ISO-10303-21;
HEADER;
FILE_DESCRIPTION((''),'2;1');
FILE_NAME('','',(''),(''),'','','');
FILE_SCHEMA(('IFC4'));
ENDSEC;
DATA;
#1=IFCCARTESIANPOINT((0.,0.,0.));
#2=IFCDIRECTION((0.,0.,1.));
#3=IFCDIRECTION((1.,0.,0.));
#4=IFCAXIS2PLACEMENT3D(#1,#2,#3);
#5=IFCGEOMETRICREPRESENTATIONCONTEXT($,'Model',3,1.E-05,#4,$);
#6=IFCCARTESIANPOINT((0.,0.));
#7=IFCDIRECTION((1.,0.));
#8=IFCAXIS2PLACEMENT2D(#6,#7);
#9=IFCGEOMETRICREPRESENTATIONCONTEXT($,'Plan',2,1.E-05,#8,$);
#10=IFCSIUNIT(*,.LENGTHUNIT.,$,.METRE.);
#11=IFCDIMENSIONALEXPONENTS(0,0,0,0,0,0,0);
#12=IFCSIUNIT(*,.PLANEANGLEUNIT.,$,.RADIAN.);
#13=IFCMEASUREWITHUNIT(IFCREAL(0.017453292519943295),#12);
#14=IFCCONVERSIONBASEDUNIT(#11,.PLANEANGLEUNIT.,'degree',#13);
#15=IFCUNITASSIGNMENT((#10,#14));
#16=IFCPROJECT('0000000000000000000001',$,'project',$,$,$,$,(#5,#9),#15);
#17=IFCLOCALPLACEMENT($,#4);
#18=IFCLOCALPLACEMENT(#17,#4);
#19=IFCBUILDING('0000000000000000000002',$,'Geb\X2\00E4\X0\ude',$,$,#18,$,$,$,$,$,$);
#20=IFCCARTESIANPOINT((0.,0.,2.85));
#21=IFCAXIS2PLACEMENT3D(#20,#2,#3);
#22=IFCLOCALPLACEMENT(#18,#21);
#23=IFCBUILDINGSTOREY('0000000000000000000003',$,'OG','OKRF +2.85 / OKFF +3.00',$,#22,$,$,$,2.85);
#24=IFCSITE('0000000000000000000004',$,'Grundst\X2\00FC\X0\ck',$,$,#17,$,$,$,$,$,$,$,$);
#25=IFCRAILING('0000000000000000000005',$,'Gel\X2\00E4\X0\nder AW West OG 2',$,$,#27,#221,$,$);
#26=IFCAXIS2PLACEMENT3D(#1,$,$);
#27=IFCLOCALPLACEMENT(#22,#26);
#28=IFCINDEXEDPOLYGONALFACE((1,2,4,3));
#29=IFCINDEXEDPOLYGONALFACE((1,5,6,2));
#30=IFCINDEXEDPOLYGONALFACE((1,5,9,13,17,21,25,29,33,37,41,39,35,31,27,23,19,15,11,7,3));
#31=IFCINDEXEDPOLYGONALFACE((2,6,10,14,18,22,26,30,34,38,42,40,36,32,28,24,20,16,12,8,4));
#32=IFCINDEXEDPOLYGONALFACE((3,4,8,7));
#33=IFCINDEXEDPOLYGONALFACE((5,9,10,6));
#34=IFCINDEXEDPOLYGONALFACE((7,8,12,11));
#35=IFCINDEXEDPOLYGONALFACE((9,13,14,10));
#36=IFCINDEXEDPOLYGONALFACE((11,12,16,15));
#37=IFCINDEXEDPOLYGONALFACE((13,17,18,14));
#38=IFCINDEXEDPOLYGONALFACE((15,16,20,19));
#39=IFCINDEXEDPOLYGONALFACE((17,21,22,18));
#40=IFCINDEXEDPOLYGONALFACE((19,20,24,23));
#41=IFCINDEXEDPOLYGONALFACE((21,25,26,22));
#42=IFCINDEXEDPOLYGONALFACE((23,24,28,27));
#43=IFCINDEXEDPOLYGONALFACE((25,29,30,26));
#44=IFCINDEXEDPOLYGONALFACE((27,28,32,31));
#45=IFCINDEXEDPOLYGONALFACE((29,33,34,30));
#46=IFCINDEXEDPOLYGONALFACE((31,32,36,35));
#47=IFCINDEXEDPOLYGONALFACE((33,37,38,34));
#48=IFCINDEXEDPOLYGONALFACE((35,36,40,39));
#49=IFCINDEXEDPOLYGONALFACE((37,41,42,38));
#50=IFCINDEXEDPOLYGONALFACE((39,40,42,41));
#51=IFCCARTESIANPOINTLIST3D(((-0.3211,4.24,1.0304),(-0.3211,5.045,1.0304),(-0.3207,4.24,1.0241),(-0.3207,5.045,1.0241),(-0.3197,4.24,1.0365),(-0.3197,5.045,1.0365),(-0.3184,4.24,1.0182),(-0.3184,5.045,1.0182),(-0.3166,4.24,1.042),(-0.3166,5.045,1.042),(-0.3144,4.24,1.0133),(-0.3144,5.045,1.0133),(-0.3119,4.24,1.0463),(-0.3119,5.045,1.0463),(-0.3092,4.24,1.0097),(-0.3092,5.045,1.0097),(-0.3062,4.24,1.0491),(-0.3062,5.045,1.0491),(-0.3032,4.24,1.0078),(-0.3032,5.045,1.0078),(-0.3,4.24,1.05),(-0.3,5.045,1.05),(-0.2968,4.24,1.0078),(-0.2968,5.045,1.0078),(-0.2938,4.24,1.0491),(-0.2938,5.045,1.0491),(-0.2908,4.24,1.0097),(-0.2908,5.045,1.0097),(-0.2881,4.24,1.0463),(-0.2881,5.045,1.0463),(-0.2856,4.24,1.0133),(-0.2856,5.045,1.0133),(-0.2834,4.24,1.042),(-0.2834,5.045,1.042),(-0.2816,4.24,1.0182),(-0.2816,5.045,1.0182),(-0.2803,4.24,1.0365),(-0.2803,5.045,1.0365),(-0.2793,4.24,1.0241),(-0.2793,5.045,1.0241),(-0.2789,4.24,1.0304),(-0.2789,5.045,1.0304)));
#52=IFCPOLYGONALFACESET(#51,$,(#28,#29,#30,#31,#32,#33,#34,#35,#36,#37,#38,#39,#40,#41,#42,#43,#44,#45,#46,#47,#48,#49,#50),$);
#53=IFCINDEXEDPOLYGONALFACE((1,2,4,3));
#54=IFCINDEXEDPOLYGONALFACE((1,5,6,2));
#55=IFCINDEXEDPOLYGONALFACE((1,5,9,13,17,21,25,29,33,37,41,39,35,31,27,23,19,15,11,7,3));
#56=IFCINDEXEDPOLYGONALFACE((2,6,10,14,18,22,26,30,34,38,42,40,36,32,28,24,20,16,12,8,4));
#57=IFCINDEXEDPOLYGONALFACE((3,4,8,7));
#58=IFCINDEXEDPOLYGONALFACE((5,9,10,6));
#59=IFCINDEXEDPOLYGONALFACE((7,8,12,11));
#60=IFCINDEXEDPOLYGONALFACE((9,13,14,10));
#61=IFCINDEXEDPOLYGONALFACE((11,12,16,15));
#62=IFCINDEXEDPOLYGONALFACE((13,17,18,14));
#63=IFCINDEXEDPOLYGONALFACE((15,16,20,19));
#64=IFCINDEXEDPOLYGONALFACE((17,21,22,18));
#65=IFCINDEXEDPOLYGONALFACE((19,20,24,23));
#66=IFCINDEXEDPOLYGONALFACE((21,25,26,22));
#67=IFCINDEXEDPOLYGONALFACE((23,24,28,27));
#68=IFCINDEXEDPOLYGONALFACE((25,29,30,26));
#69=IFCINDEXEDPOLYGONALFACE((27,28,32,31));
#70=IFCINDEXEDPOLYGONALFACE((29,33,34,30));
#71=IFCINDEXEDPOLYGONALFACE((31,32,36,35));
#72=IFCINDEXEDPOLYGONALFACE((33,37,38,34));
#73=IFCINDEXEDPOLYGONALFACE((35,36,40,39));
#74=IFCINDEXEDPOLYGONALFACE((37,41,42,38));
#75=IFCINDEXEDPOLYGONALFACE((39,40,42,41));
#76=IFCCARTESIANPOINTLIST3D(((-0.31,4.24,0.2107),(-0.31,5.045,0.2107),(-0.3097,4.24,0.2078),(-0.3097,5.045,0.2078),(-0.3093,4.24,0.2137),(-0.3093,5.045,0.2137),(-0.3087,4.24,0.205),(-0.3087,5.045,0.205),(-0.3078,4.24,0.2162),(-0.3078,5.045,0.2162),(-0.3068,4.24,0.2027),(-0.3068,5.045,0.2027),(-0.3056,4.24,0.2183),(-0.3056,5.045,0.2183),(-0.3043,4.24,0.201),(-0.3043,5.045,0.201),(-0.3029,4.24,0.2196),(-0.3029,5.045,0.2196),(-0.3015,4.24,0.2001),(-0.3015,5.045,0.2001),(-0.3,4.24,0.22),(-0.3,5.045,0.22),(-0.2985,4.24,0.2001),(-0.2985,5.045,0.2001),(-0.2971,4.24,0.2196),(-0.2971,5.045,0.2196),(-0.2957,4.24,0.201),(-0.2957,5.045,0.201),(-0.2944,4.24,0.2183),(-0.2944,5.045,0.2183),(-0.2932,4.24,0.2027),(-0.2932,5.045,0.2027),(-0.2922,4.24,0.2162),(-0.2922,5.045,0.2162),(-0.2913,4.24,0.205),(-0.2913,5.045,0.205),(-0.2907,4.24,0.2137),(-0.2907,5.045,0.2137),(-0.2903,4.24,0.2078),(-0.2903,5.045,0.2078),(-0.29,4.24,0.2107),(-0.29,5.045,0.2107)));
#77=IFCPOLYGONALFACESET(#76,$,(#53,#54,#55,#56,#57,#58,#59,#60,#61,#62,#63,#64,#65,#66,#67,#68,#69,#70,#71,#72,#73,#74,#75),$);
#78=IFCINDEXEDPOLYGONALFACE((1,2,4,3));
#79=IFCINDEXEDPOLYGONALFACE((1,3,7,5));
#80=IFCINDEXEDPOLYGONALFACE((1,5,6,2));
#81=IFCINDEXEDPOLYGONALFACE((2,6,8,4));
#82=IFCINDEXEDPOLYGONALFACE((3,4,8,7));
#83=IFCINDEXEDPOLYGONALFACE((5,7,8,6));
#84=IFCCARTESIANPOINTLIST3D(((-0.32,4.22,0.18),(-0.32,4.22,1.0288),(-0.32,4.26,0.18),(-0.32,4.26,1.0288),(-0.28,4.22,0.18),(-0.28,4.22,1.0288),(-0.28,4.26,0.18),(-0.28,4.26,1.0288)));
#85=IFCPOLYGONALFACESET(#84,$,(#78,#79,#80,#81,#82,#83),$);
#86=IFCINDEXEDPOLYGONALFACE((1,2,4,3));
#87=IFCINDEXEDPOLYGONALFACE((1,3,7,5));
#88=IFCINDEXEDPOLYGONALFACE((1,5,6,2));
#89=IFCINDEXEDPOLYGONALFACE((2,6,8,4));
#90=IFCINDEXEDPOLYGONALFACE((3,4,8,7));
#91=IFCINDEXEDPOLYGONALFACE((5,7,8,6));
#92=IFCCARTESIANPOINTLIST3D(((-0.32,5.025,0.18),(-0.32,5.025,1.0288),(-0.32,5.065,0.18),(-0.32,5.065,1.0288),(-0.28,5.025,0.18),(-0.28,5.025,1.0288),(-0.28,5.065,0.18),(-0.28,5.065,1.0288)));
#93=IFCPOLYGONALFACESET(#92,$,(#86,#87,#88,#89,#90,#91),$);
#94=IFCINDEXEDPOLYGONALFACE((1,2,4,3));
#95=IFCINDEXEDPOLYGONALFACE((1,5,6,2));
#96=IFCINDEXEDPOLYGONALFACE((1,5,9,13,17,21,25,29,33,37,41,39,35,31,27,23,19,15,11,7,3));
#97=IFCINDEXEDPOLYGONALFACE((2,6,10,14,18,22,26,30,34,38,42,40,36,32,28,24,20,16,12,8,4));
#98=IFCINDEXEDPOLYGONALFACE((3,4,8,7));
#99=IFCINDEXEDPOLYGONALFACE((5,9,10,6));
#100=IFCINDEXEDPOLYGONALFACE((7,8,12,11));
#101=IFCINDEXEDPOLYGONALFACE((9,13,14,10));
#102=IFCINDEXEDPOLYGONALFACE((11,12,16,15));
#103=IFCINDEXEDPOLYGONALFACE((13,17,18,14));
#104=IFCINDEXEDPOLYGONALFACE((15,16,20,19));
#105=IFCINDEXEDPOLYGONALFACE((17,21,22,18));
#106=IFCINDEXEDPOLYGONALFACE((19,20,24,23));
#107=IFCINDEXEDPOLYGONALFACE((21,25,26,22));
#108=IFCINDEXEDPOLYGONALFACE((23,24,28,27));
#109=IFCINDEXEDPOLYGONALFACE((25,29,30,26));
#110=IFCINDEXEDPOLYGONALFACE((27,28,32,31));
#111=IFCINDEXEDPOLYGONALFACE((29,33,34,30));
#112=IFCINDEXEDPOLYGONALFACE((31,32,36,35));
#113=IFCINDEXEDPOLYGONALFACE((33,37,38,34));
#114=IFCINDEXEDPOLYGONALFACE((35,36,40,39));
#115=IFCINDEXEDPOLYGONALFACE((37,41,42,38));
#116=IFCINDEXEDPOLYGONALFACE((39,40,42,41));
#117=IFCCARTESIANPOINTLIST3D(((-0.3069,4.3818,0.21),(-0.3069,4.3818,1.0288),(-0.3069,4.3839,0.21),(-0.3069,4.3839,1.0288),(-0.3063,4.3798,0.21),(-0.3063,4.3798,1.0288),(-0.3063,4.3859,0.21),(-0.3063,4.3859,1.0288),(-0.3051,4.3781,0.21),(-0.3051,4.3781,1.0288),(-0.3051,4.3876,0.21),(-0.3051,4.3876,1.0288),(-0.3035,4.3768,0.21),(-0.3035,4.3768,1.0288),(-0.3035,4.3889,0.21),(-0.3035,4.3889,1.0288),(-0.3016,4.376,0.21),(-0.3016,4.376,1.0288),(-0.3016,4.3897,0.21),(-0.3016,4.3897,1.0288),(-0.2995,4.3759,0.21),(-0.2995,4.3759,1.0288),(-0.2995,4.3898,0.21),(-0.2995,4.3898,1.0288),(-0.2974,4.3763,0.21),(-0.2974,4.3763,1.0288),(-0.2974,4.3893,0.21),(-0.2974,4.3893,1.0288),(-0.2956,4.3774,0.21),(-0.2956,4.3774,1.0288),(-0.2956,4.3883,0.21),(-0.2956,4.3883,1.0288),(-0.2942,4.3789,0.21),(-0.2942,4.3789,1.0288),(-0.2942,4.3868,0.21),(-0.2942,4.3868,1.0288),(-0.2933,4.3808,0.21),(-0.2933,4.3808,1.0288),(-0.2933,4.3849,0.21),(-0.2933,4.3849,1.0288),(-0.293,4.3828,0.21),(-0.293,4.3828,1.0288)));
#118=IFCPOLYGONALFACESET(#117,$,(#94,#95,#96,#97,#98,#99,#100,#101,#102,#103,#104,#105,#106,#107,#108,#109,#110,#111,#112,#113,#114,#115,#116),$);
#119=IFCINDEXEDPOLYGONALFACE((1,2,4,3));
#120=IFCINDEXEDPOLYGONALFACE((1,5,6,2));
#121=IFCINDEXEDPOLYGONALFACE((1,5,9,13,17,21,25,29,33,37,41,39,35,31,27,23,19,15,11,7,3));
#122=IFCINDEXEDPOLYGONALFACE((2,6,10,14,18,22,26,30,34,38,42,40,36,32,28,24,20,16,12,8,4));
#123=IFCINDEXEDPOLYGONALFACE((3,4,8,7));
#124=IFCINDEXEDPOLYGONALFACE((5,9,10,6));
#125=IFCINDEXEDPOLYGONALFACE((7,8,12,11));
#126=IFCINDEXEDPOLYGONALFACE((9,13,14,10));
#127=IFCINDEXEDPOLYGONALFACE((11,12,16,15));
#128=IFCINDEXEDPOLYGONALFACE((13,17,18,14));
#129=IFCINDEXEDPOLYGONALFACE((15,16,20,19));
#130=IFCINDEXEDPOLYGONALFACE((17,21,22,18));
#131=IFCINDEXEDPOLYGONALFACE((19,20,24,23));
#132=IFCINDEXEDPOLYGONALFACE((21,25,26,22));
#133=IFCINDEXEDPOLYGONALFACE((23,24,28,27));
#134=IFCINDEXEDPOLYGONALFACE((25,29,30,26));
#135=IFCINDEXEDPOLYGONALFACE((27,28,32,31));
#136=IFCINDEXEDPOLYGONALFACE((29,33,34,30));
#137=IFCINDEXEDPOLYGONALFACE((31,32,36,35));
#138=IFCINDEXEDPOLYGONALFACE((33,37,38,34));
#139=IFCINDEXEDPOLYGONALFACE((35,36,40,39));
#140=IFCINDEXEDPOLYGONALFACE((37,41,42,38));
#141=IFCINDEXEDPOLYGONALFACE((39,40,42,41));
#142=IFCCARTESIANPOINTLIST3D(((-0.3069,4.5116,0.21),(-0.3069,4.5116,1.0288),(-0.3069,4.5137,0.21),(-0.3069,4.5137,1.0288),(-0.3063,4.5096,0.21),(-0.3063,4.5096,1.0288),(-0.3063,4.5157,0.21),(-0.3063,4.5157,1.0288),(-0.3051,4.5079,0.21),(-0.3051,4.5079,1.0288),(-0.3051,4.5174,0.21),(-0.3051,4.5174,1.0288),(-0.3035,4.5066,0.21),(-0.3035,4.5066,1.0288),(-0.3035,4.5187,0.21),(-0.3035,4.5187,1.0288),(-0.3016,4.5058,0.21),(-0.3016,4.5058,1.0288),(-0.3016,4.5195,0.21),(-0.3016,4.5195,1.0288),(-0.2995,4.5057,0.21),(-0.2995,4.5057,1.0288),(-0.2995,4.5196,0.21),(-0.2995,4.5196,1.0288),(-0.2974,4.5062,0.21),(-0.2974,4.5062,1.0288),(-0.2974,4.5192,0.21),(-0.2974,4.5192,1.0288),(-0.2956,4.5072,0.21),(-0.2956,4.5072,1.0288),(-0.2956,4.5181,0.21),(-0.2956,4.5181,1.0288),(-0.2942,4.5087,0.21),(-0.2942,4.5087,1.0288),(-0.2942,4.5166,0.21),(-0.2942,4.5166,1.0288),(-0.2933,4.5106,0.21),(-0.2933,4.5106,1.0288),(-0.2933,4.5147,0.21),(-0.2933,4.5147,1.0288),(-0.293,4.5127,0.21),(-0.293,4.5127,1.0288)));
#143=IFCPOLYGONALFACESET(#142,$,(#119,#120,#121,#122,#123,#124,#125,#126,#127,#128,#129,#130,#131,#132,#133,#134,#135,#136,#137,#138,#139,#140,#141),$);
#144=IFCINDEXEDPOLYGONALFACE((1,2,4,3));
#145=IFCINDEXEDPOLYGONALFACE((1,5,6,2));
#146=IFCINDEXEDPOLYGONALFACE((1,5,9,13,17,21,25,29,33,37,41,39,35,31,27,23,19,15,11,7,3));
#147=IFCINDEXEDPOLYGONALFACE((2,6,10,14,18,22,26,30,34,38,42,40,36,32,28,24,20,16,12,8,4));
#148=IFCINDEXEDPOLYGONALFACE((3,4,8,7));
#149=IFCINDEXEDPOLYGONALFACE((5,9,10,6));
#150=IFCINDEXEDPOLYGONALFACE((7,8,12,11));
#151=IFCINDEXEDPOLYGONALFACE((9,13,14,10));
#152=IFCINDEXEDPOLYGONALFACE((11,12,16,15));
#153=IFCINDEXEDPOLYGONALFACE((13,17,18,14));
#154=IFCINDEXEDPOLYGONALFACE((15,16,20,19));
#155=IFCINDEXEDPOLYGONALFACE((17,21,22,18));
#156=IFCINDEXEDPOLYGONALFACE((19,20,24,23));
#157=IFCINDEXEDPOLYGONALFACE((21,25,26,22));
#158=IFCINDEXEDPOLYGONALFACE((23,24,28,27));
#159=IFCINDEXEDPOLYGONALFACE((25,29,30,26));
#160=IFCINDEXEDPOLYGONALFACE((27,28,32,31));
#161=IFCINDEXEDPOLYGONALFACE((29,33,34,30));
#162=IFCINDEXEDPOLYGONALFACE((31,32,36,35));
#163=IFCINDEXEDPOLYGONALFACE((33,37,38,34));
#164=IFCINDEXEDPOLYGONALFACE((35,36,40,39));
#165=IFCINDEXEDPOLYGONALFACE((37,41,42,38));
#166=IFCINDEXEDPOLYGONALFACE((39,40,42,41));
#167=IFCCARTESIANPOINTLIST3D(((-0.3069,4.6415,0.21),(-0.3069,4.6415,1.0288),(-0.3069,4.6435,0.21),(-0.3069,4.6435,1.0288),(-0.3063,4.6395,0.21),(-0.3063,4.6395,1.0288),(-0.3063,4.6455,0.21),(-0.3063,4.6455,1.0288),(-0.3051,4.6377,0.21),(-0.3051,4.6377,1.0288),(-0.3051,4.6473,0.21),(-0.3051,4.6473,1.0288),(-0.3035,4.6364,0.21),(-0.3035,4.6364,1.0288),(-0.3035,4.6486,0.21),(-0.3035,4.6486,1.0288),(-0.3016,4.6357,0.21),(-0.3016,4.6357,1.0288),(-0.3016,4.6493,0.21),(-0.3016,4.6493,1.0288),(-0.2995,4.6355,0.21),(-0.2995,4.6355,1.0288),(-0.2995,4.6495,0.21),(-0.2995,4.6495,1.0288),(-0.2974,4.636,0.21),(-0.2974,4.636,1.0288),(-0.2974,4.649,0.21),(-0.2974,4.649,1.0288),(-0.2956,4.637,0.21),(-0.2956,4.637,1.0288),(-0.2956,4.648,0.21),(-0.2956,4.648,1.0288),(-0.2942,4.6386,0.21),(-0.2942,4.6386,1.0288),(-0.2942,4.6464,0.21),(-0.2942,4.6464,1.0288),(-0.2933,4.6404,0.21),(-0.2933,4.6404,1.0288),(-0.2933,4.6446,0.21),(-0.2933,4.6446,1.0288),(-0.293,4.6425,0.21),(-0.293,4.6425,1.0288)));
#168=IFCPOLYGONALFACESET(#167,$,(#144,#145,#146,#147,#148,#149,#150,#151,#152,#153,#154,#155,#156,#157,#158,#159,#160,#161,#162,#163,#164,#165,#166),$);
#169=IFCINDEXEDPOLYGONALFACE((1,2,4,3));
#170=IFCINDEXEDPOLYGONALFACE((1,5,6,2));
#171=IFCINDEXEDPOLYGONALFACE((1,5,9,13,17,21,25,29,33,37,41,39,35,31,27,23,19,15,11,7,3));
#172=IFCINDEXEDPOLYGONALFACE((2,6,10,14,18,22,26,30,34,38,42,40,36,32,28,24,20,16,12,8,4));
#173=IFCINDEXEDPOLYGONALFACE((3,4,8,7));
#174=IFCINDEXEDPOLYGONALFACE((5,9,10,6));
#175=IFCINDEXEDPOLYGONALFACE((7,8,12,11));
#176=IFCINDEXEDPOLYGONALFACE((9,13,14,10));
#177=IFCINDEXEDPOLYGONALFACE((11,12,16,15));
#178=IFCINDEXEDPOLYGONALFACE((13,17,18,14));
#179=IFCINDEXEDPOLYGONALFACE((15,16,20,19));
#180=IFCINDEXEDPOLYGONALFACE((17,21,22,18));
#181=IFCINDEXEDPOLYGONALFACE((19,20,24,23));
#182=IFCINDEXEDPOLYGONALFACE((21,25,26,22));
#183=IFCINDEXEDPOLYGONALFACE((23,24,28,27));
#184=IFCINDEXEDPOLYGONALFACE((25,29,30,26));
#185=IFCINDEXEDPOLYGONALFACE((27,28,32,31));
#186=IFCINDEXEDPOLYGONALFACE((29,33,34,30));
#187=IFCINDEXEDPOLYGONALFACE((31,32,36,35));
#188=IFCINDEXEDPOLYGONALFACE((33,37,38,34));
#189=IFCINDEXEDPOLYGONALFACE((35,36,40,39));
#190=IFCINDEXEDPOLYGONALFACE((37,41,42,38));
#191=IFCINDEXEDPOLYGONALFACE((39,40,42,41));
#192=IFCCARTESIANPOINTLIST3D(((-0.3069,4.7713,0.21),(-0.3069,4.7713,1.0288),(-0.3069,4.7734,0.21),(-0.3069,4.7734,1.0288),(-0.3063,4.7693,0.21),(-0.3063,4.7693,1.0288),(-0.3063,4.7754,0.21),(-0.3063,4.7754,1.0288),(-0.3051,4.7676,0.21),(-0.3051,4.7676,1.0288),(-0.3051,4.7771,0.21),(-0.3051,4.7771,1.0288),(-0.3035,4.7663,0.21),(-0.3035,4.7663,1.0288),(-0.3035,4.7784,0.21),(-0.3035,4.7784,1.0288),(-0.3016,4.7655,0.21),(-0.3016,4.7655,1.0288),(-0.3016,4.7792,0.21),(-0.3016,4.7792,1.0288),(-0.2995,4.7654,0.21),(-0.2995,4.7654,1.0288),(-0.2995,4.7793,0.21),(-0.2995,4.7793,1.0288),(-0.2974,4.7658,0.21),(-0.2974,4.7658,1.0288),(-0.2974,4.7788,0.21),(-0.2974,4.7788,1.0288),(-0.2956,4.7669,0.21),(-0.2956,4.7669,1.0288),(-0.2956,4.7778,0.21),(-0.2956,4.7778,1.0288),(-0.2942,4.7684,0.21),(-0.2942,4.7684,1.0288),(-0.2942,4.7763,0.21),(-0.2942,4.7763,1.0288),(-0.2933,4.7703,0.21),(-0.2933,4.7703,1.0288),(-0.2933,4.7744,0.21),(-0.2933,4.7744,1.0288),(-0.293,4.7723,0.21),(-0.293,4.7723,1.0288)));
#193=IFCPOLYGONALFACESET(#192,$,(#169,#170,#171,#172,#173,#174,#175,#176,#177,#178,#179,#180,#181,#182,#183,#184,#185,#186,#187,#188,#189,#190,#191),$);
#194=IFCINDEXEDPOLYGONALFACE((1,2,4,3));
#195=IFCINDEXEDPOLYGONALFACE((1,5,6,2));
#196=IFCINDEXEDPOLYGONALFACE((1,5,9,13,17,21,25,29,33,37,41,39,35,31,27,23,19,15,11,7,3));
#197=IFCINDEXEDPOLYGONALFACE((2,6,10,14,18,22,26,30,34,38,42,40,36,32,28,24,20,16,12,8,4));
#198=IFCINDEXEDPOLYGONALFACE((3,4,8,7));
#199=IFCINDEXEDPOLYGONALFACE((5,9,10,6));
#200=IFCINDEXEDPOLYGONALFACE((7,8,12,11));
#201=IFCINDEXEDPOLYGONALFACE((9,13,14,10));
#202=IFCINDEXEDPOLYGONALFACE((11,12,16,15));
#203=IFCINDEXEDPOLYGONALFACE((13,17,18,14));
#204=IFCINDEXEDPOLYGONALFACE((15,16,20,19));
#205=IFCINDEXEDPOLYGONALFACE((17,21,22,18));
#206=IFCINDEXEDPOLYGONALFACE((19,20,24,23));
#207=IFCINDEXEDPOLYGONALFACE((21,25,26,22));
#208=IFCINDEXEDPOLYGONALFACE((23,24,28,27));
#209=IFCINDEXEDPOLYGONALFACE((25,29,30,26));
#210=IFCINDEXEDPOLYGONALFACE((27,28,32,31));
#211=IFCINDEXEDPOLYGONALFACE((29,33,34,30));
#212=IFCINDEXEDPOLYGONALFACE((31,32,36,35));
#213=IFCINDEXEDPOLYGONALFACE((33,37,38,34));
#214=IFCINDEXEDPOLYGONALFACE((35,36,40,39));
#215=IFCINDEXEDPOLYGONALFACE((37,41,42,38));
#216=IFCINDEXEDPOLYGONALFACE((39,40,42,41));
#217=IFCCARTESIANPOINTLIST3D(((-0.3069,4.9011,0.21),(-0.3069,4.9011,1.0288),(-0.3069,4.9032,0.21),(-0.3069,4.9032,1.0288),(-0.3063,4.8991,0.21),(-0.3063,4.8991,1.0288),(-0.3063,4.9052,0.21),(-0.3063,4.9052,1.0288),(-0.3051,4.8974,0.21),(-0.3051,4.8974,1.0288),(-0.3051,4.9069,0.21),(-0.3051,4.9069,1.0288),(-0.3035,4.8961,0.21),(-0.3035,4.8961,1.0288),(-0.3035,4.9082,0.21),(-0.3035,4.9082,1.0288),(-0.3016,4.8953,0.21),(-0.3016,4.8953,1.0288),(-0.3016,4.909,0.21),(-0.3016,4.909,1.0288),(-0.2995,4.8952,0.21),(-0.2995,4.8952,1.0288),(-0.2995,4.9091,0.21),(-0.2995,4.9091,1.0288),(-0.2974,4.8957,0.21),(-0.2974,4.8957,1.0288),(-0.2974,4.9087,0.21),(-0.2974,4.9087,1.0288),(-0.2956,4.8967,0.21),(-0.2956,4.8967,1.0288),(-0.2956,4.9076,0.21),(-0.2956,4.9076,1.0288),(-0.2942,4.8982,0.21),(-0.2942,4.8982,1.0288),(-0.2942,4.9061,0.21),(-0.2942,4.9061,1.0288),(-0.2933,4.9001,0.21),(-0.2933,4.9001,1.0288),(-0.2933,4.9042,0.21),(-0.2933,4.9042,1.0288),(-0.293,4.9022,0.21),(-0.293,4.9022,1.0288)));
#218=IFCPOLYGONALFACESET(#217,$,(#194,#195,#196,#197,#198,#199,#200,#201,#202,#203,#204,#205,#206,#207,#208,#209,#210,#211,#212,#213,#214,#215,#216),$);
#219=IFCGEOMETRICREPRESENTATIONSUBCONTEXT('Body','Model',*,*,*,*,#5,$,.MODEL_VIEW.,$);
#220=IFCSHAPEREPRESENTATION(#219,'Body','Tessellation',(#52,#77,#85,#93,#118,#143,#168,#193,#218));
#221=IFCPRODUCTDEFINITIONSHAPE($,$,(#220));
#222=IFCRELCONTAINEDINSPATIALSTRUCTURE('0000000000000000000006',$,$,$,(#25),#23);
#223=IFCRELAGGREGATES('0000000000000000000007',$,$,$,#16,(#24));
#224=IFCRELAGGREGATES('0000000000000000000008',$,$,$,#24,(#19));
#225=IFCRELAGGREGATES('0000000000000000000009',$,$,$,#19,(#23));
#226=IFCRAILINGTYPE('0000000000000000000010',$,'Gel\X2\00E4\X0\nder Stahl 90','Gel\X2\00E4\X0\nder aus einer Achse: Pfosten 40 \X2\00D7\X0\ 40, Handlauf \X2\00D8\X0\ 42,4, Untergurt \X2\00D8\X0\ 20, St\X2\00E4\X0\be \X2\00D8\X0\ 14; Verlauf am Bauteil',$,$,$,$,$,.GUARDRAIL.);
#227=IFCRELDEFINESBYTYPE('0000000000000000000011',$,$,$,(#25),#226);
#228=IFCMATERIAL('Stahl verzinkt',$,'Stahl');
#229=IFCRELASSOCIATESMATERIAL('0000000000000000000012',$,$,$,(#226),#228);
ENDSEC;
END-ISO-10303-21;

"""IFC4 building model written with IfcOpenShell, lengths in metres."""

from ifc_helpers import new_model, entity, si_unit, converted_unit, frame, origin_with_axes, origin_2d_with_axis, place, context, subcontext, project, spatial, polyline, outline, extrude, material, type_object, element, save


model = new_model("IFC4")

# Units and contexts
model_context = context("Model", 3, precision=1e-05, world=origin_with_axes())
plan_context = context("Plan", 2, precision=1e-05, world=origin_2d_with_axis())
body_context = subcontext(model_context, "Body", "Model", "MODEL_VIEW")
ifc_project = project(units=[si_unit("LENGTHUNIT", "METRE"), converted_unit("PLANEANGLEUNIT", "degree", entity("IfcReal", 0.017453292519943295), si_unit("PLANEANGLEUNIT", "RADIAN"), dimensions=[0, 0, 0, 0, 0, 0, 0])], contexts=[model_context, plan_context])

# Site, building, storey
site_placement = place(None, origin_with_axes())
site = spatial("IfcSite", under=ifc_project, at=site_placement, Name="Grundstück")
building_placement = place(site_placement, origin_with_axes())
building = spatial("IfcBuilding", under=site, at=building_placement, Name="Gebäude")
storey_placement = place(building_placement, frame((0.0, 0.0, 2.85), z_axis=(0.0, 0.0, 1.0), x_axis=(1.0, 0.0, 0.0)))
storey = spatial("IfcBuildingStorey", under=building, at=storey_placement, Name="OG", Description="OKRF +2.85 / OKFF +3.00", Elevation=2.85)

# Railing
ifc_material_1 = material(Name="Stahl verzinkt", Category="Stahl")
railing_type = type_object("IfcRailingType", Name="Geländer Stahl 90", Description="Geländer aus einer Achse: Pfosten 40 × 40, Handlauf Ø 42,4, Untergurt Ø 20, Stäbe Ø 14; Verlauf am Bauteil", PredefinedType="GUARDRAIL", material=ifc_material_1)
railing_1_placement = place(storey_placement, frame((0.0, 0.0, -2.85), z_axis=(0.0, 0.0, 1.0), x_axis=(1.0, 0.0, 0.0)))
element("IfcRailing", 1, at=railing_1_placement, inside=storey, type_object=railing_type, Name="Geländer AW West OG 2", context=body_context, shape_type="SolidModel", body=[
    entity("IfcSweptDiskSolid", entity("IfcPolyline", [entity("IfcCartesianPoint", [-0.3, 4.24, 3.8788]), entity("IfcCartesianPoint", [-0.3, 5.045, 3.8788])]), 0.0212),
    entity("IfcSweptDiskSolid", entity("IfcPolyline", [entity("IfcCartesianPoint", [-0.3, 4.24, 3.06]), entity("IfcCartesianPoint", [-0.3, 5.045, 3.06])]), 0.01),
    extrude(outline(polyline([(-0.28, 4.22), (-0.28, 4.26), (-0.32, 4.26), (-0.32, 4.22), (-0.28, 4.22)])), frame((0.0, 0.0, 3.03), z_axis=(0.0, 0.0, 1.0), x_axis=(1.0, 0.0, 0.0)), (0.0, 0.0, 1.0), 0.8488),
    extrude(outline(polyline([(-0.28, 5.025), (-0.28, 5.065), (-0.32, 5.065), (-0.32, 5.025), (-0.28, 5.025)])), frame((0.0, 0.0, 3.03), z_axis=(0.0, 0.0, 1.0), x_axis=(1.0, 0.0, 0.0)), (0.0, 0.0, 1.0), 0.8488),
    entity("IfcSweptDiskSolid", entity("IfcPolyline", [entity("IfcCartesianPoint", [-0.3, 4.3828, 3.06]), entity("IfcCartesianPoint", [-0.3, 4.3828, 3.8788])]), 0.007),
    entity("IfcSweptDiskSolid", entity("IfcPolyline", [entity("IfcCartesianPoint", [-0.3, 4.5127, 3.06]), entity("IfcCartesianPoint", [-0.3, 4.5127, 3.8788])]), 0.007),
    entity("IfcSweptDiskSolid", entity("IfcPolyline", [entity("IfcCartesianPoint", [-0.3, 4.6425, 3.06]), entity("IfcCartesianPoint", [-0.3, 4.6425, 3.8788])]), 0.007),
    entity("IfcSweptDiskSolid", entity("IfcPolyline", [entity("IfcCartesianPoint", [-0.3, 4.7723, 3.06]), entity("IfcCartesianPoint", [-0.3, 4.7723, 3.8788])]), 0.007),
    entity("IfcSweptDiskSolid", entity("IfcPolyline", [entity("IfcCartesianPoint", [-0.3, 4.9022, 3.06]), entity("IfcCartesianPoint", [-0.3, 4.9022, 3.8788])]), 0.007),
])

save(model, "model.ifc")
